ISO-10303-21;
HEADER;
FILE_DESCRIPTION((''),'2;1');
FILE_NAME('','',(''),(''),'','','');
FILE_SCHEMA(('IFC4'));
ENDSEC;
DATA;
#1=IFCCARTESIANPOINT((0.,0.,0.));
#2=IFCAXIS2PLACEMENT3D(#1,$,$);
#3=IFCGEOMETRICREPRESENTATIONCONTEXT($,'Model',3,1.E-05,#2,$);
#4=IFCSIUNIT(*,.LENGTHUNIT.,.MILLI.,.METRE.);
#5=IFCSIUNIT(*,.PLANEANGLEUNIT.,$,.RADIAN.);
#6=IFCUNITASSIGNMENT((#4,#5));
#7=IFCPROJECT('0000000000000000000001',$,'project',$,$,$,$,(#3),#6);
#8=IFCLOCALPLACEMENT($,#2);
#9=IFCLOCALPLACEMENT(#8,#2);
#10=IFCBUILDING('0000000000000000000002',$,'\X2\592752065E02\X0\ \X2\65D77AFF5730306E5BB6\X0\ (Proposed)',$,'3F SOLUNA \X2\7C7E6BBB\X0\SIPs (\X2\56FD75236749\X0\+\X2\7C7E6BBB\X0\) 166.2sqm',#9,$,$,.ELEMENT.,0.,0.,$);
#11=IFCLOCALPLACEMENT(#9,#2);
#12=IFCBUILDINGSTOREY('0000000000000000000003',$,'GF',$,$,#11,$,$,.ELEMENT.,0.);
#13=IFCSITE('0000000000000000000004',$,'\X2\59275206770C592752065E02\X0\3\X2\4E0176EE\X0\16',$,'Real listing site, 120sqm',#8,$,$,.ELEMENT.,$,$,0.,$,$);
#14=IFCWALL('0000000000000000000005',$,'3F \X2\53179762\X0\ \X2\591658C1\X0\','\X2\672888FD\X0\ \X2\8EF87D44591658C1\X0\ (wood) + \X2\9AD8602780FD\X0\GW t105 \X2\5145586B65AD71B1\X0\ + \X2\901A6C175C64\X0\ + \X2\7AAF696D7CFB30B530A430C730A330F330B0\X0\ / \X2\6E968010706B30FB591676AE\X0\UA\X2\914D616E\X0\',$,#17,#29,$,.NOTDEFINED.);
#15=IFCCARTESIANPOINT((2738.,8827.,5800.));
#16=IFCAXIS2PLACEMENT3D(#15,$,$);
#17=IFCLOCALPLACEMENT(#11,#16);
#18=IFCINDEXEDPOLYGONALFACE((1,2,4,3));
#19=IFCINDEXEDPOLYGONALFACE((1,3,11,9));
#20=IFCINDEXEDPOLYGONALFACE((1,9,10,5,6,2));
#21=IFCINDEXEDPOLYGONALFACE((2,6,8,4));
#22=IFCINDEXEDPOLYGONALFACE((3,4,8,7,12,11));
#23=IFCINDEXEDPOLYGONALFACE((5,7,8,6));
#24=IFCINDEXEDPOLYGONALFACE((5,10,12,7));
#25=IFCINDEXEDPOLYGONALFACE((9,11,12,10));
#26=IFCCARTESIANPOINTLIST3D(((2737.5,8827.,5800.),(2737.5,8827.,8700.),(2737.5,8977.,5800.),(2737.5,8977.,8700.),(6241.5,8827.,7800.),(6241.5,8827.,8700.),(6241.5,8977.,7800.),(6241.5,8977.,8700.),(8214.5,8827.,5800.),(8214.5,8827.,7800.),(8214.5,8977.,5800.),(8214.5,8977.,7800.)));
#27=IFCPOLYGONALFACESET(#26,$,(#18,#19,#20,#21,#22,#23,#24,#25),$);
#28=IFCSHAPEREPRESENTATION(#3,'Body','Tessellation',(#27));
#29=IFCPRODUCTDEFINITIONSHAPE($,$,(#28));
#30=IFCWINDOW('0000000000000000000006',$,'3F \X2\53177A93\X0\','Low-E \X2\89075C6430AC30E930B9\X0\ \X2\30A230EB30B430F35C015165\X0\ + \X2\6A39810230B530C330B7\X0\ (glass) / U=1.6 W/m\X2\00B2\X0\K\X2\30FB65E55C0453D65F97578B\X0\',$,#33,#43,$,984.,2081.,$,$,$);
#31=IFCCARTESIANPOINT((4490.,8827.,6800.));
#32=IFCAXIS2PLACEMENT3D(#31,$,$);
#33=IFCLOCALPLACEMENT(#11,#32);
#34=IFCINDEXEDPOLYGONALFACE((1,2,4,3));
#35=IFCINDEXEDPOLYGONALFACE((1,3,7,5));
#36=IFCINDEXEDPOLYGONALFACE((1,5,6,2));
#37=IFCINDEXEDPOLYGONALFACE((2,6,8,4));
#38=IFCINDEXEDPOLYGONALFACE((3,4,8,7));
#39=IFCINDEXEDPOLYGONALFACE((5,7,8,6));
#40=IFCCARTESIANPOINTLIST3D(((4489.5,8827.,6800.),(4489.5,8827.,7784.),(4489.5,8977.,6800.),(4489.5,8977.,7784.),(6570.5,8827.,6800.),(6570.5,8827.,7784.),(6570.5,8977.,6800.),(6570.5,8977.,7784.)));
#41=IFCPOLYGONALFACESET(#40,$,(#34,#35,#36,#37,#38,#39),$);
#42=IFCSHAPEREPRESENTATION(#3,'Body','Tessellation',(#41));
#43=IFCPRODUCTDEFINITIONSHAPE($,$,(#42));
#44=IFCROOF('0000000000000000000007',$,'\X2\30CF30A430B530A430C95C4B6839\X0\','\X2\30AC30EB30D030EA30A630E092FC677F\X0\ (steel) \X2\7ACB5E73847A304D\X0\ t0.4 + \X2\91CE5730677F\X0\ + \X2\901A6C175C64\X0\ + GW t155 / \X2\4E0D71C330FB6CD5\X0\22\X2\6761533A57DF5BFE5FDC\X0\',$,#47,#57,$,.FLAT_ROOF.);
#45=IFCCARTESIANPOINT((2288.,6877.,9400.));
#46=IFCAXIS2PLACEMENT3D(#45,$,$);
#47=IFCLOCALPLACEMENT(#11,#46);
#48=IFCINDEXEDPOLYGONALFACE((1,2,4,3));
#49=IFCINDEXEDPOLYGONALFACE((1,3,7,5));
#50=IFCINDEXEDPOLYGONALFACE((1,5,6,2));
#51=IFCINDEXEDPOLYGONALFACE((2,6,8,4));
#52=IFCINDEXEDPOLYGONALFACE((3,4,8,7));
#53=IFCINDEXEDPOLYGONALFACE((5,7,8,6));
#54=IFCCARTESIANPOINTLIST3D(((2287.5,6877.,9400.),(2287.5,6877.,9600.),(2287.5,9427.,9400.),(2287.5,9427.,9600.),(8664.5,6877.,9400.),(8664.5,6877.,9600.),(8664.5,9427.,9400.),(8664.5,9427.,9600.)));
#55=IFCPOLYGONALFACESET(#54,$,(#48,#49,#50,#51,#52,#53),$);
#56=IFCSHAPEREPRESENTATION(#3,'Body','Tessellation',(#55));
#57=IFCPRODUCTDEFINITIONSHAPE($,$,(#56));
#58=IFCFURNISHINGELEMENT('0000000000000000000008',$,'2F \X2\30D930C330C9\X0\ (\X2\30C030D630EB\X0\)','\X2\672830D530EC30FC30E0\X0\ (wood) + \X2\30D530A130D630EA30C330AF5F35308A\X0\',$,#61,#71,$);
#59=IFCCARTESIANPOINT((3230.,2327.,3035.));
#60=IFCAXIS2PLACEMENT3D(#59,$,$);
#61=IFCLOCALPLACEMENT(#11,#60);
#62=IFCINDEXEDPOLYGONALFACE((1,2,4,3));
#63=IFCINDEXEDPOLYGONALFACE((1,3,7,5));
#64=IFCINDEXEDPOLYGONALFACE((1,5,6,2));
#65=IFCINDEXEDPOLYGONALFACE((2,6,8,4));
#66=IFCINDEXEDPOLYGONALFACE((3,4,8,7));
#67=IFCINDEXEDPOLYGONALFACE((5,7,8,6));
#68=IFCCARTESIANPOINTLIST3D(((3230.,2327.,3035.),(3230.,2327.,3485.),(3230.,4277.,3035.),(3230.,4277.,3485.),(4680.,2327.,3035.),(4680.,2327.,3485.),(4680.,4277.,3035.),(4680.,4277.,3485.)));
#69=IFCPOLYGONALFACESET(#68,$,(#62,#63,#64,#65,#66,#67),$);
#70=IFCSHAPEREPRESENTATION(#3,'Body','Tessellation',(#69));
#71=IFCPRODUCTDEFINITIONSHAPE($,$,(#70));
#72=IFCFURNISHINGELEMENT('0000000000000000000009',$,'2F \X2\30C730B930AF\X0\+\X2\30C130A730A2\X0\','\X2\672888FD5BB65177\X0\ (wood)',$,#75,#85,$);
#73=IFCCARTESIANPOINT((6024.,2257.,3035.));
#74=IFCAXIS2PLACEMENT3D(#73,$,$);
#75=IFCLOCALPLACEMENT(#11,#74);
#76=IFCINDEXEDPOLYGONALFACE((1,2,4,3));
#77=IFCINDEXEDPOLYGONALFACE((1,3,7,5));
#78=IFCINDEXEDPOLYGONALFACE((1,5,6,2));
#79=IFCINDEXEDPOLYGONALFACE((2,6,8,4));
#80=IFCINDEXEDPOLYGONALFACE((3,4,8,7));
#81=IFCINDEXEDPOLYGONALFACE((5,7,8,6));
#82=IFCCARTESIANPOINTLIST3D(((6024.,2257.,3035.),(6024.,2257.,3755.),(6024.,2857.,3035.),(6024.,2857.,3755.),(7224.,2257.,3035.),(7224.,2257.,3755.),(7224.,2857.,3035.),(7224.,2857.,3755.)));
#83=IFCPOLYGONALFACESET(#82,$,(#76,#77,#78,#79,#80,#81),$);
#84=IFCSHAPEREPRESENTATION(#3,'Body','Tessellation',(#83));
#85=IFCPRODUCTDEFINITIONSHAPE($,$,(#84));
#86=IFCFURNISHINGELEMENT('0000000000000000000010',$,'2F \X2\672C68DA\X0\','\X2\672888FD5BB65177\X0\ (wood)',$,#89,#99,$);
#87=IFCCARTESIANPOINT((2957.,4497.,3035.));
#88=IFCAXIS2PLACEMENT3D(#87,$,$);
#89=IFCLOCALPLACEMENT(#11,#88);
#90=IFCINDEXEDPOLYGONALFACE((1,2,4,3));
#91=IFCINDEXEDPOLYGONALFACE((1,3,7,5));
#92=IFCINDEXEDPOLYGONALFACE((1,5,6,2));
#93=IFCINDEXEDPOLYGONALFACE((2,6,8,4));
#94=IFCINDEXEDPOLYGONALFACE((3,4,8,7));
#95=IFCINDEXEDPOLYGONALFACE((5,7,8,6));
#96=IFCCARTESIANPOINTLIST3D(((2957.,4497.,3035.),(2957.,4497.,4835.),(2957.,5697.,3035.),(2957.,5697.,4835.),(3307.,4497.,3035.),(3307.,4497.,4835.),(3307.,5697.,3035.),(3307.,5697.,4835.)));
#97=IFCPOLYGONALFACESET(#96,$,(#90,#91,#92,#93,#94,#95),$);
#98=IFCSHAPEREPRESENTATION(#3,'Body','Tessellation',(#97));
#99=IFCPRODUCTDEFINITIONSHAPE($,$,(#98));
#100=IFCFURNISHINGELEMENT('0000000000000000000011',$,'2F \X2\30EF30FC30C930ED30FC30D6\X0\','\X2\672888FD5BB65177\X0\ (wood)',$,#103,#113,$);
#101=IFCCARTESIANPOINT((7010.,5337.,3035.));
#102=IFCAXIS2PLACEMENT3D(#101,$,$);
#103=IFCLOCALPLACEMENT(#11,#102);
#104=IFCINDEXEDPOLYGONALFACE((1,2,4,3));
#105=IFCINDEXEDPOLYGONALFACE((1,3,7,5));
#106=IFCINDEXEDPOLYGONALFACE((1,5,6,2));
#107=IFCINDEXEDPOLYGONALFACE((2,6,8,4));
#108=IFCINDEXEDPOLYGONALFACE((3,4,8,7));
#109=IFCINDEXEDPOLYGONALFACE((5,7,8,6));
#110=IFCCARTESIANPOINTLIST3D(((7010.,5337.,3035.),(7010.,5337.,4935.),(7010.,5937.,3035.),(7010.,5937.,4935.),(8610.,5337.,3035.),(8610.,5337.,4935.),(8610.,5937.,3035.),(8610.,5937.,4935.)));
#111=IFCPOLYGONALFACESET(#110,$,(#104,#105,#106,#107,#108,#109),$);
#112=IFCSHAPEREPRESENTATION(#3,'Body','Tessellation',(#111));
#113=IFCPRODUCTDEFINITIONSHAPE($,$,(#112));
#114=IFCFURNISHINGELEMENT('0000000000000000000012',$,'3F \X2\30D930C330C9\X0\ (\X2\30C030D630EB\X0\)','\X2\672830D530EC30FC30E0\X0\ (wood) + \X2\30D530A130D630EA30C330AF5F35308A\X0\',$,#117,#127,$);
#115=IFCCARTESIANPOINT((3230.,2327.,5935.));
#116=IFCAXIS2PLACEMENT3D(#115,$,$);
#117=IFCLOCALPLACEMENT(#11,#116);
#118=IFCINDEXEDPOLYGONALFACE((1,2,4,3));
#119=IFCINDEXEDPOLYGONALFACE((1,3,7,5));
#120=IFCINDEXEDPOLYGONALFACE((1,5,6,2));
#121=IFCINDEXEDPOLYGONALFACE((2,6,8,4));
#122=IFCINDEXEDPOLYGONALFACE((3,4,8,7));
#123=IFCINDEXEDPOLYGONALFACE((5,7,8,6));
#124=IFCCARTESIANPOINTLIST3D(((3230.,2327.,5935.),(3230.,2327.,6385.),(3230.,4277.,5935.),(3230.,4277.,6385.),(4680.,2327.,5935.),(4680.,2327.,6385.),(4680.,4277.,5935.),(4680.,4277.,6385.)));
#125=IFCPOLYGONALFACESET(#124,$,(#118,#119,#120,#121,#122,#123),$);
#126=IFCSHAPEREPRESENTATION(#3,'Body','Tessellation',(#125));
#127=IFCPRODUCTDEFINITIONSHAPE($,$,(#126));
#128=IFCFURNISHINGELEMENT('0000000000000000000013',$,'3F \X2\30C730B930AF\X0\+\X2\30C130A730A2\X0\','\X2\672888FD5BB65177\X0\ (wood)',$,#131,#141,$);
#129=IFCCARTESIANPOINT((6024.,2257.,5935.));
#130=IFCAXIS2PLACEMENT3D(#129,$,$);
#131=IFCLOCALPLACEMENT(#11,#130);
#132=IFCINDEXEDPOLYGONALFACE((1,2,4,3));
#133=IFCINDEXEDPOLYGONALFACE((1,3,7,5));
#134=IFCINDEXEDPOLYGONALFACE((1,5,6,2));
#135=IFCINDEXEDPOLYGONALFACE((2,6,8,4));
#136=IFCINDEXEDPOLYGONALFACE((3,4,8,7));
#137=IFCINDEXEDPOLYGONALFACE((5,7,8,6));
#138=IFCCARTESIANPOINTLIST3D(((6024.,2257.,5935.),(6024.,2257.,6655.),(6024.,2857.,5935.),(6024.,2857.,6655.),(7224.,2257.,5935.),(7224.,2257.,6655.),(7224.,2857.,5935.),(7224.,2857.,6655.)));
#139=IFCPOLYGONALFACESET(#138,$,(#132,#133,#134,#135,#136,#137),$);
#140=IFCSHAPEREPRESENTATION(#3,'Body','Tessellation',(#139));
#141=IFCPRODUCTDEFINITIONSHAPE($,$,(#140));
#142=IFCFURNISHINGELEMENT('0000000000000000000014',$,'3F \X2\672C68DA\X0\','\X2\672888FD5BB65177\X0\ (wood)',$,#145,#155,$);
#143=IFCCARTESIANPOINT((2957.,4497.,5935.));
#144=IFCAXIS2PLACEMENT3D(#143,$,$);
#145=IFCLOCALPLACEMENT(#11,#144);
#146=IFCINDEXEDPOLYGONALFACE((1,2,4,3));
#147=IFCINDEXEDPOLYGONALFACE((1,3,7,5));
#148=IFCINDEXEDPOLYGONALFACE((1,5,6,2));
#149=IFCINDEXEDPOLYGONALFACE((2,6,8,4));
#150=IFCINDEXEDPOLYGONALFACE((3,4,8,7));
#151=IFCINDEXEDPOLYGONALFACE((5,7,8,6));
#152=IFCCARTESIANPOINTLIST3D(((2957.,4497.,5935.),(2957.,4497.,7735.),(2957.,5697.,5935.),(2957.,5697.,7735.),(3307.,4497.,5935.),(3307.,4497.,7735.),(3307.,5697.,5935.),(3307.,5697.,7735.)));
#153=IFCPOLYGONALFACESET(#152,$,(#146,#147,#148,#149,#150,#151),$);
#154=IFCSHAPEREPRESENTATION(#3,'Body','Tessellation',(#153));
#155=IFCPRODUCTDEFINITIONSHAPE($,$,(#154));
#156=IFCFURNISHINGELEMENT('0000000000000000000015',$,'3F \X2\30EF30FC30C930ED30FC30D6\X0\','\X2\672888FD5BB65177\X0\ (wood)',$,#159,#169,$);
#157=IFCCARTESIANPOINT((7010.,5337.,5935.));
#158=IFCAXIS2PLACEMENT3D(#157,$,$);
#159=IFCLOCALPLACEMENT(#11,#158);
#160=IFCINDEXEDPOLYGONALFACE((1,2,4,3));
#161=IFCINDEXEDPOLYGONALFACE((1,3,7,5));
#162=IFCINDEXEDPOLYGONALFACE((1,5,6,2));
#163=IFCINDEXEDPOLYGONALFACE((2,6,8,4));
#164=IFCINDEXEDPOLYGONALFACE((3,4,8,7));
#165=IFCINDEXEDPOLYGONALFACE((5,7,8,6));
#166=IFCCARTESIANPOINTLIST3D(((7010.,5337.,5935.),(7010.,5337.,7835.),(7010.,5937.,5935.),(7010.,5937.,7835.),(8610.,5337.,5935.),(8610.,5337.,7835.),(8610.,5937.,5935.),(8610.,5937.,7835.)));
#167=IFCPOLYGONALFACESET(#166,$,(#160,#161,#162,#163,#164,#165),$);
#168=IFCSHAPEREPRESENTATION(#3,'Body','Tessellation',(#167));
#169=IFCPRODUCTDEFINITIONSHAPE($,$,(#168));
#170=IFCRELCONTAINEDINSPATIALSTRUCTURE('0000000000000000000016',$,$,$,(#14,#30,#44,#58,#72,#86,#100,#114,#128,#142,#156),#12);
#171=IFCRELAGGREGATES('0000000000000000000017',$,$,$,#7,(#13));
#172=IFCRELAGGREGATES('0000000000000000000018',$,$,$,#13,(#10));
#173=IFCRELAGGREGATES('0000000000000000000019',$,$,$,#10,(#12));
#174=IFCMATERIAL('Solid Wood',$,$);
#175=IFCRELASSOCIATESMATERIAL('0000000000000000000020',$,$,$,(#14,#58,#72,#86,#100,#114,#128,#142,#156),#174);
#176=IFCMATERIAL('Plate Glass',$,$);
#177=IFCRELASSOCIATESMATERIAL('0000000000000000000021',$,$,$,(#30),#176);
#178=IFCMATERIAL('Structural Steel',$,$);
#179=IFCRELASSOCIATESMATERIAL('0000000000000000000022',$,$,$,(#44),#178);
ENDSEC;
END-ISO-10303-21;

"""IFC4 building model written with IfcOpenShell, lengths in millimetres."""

from ifc_helpers import new_model, si_unit, frame, frame_2d, origin, place, context, project, spatial, rectangle, extrude, material, element, fill, save


model = new_model("IFC4")

# Units and contexts
model_context = context("Model", 3, precision=1e-05, world=origin())
ifc_project = project(units=[si_unit("LENGTHUNIT", "METRE", prefix="MILLI"), si_unit("PLANEANGLEUNIT", "RADIAN")], contexts=[model_context])

# Site, building, storey
site_placement = place(None, origin())
site = spatial("IfcSite", under=ifc_project, at=site_placement, Name="大分県大分市3丁目16", ObjectType="Real listing site, 120sqm", CompositionType="ELEMENT", RefElevation=0.0)
building_placement = place(site_placement, origin())
building = spatial("IfcBuilding", under=site, at=building_placement, Name="大分市 旗竿地の家 (Proposed)", ObjectType="3F SOLUNA 籾殻SIPs (国産杉+籾殻) 166.2sqm", CompositionType="ELEMENT", ElevationOfRefHeight=0.0, ElevationOfTerrain=0.0)
storey_placement = place(building_placement, origin())
storey = spatial("IfcBuildingStorey", under=building, at=storey_placement, Name="GF", CompositionType="ELEMENT", Elevation=0.0)

# Shared definitions
ifc_material_1 = material(Name="Solid Wood")

# Wall, opening, window
wall_1_placement = place(storey_placement, frame((2738.0, 8827.0, 5800.0)))
wall_1 = element("IfcWall", 1, at=wall_1_placement, inside=storey, material=ifc_material_1, Name="3F 北面 外壁", Description="木製 軸組外壁 (wood) + 高性能GW t105 充填断熱 + 通気層 + 窯業系サイディング / 準耐火・外皮UA配慮", PredefinedType="NOTDEFINED", context=model_context, shape_type="SweptSolid", body=[
    extrude(rectangle(XDim=5477.0, YDim=150.0, at=frame_2d((2738.0, 75.0))), frame((2738.0, 8827.0, 5800.0)), (0.0, 0.0, 1.0), 2900.0),
])
opening_1_placement = place(storey_placement, frame((4490.0, 8827.0, 6800.0)))
opening_1 = element("IfcOpeningElement", 2, at=opening_1_placement, cuts=wall_1, PredefinedType="NOTDEFINED", context=model_context, shape_type="SweptSolid", body=[
    extrude(rectangle(XDim=2081.0, YDim=150.0, at=frame_2d((1040.0, 75.0))), frame((4490.0, 8827.0, 6800.0)), (0.0, 0.0, 1.0), 984.0),
])
ifc_material_2 = material(Name="Plate Glass")
window_1_placement = place(storey_placement, frame((4490.0, 8827.0, 6800.0)))
window_1 = element("IfcWindow", 3, at=window_1_placement, inside=storey, material=ifc_material_2, Name="3F 北窓", Description="Low-E 複層ガラス アルゴン封入 + 樹脂サッシ (glass) / U=1.6 W/m²K・日射取得型", OverallHeight=984.0, OverallWidth=2081.0, context=model_context, shape_type="SweptSolid", body=[
    extrude(rectangle(XDim=2081.0, YDim=150.0, at=frame_2d((1040.0, 75.0))), frame((4490.0, 8827.0, 6800.0)), (0.0, 0.0, 1.0), 984.0),
])
fill(opening_1, window_1)

# Roof
ifc_material_3 = material(Name="Structural Steel")
roof_placement = place(storey_placement, frame((2288.0, 6877.0, 9400.0)))
element("IfcRoof", 4, at=roof_placement, inside=storey, material=ifc_material_3, Name="ハイサイド屋根", Description="ガルバリウム鋼板 (steel) 立平葺き t0.4 + 野地板 + 通気層 + GW t155 / 不燃・法22条区域対応", PredefinedType="FLAT_ROOF", context=model_context, shape_type="SweptSolid", body=[
    extrude(rectangle(XDim=6377.0, YDim=2550.0, at=frame_2d((3188.0, 1275.0))), frame((2288.0, 6877.0, 9400.0)), (0.0, 0.0, 1.0), 200.0),
])

# Furnishing elements
furnishing_1_placement = place(storey_placement, frame((3230.0, 2327.0, 3035.0)))
element("IfcFurnishingElement", 5, at=furnishing_1_placement, inside=storey, material=ifc_material_1, Name="2F ベッド (ダブル)", Description="木フレーム (wood) + ファブリック張り", context=model_context, shape_type="SweptSolid", body=[
    extrude(rectangle(XDim=1450.0, YDim=1950.0, at=frame_2d((725.0, 975.0))), frame((3230.0, 2327.0, 3035.0)), (0.0, 0.0, 1.0), 450.0),
])
furnishing_2_placement = place(storey_placement, frame((6024.0, 2257.0, 3035.0)))
element("IfcFurnishingElement", 6, at=furnishing_2_placement, inside=storey, material=ifc_material_1, Name="2F デスク+チェア", Description="木製家具 (wood)", context=model_context, shape_type="SweptSolid", body=[
    extrude(rectangle(XDim=1200.0, YDim=600.0, at=frame_2d((600.0, 300.0))), frame((6024.0, 2257.0, 3035.0)), (0.0, 0.0, 1.0), 720.0),
])
furnishing_3_placement = place(storey_placement, frame((2957.0, 4497.0, 3035.0)))
element("IfcFurnishingElement", 7, at=furnishing_3_placement, inside=storey, material=ifc_material_1, Name="2F 本棚", Description="木製家具 (wood)", context=model_context, shape_type="SweptSolid", body=[
    extrude(rectangle(XDim=350.0, YDim=1200.0, at=frame_2d((175.0, 600.0))), frame((2957.0, 4497.0, 3035.0)), (0.0, 0.0, 1.0), 1800.0),
])
furnishing_4_placement = place(storey_placement, frame((7010.0, 5337.0, 3035.0)))
element("IfcFurnishingElement", 8, at=furnishing_4_placement, inside=storey, material=ifc_material_1, Name="2F ワードローブ", Description="木製家具 (wood)", context=model_context, shape_type="SweptSolid", body=[
    extrude(rectangle(XDim=1600.0, YDim=600.0, at=frame_2d((800.0, 300.0))), frame((7010.0, 5337.0, 3035.0)), (0.0, 0.0, 1.0), 1900.0),
])
furnishing_5_placement = place(storey_placement, frame((3230.0, 2327.0, 5935.0)))
element("IfcFurnishingElement", 9, at=furnishing_5_placement, inside=storey, material=ifc_material_1, Name="3F ベッド (ダブル)", Description="木フレーム (wood) + ファブリック張り", context=model_context, shape_type="SweptSolid", body=[
    extrude(rectangle(XDim=1450.0, YDim=1950.0, at=frame_2d((725.0, 975.0))), frame((3230.0, 2327.0, 5935.0)), (0.0, 0.0, 1.0), 450.0),
])
furnishing_6_placement = place(storey_placement, frame((6024.0, 2257.0, 5935.0)))
element("IfcFurnishingElement", 10, at=furnishing_6_placement, inside=storey, material=ifc_material_1, Name="3F デスク+チェア", Description="木製家具 (wood)", context=model_context, shape_type="SweptSolid", body=[
    extrude(rectangle(XDim=1200.0, YDim=600.0, at=frame_2d((600.0, 300.0))), frame((6024.0, 2257.0, 5935.0)), (0.0, 0.0, 1.0), 720.0),
])
furnishing_7_placement = place(storey_placement, frame((2957.0, 4497.0, 5935.0)))
element("IfcFurnishingElement", 11, at=furnishing_7_placement, inside=storey, material=ifc_material_1, Name="3F 本棚", Description="木製家具 (wood)", context=model_context, shape_type="SweptSolid", body=[
    extrude(rectangle(XDim=350.0, YDim=1200.0, at=frame_2d((175.0, 600.0))), frame((2957.0, 4497.0, 5935.0)), (0.0, 0.0, 1.0), 1800.0),
])
furnishing_8_placement = place(storey_placement, frame((7010.0, 5337.0, 5935.0)))
element("IfcFurnishingElement", 12, at=furnishing_8_placement, inside=storey, material=ifc_material_1, Name="3F ワードローブ", Description="木製家具 (wood)", context=model_context, shape_type="SweptSolid", body=[
    extrude(rectangle(XDim=1600.0, YDim=600.0, at=frame_2d((800.0, 300.0))), frame((7010.0, 5337.0, 5935.0)), (0.0, 0.0, 1.0), 1900.0),
])

save(model, "model.ifc")
